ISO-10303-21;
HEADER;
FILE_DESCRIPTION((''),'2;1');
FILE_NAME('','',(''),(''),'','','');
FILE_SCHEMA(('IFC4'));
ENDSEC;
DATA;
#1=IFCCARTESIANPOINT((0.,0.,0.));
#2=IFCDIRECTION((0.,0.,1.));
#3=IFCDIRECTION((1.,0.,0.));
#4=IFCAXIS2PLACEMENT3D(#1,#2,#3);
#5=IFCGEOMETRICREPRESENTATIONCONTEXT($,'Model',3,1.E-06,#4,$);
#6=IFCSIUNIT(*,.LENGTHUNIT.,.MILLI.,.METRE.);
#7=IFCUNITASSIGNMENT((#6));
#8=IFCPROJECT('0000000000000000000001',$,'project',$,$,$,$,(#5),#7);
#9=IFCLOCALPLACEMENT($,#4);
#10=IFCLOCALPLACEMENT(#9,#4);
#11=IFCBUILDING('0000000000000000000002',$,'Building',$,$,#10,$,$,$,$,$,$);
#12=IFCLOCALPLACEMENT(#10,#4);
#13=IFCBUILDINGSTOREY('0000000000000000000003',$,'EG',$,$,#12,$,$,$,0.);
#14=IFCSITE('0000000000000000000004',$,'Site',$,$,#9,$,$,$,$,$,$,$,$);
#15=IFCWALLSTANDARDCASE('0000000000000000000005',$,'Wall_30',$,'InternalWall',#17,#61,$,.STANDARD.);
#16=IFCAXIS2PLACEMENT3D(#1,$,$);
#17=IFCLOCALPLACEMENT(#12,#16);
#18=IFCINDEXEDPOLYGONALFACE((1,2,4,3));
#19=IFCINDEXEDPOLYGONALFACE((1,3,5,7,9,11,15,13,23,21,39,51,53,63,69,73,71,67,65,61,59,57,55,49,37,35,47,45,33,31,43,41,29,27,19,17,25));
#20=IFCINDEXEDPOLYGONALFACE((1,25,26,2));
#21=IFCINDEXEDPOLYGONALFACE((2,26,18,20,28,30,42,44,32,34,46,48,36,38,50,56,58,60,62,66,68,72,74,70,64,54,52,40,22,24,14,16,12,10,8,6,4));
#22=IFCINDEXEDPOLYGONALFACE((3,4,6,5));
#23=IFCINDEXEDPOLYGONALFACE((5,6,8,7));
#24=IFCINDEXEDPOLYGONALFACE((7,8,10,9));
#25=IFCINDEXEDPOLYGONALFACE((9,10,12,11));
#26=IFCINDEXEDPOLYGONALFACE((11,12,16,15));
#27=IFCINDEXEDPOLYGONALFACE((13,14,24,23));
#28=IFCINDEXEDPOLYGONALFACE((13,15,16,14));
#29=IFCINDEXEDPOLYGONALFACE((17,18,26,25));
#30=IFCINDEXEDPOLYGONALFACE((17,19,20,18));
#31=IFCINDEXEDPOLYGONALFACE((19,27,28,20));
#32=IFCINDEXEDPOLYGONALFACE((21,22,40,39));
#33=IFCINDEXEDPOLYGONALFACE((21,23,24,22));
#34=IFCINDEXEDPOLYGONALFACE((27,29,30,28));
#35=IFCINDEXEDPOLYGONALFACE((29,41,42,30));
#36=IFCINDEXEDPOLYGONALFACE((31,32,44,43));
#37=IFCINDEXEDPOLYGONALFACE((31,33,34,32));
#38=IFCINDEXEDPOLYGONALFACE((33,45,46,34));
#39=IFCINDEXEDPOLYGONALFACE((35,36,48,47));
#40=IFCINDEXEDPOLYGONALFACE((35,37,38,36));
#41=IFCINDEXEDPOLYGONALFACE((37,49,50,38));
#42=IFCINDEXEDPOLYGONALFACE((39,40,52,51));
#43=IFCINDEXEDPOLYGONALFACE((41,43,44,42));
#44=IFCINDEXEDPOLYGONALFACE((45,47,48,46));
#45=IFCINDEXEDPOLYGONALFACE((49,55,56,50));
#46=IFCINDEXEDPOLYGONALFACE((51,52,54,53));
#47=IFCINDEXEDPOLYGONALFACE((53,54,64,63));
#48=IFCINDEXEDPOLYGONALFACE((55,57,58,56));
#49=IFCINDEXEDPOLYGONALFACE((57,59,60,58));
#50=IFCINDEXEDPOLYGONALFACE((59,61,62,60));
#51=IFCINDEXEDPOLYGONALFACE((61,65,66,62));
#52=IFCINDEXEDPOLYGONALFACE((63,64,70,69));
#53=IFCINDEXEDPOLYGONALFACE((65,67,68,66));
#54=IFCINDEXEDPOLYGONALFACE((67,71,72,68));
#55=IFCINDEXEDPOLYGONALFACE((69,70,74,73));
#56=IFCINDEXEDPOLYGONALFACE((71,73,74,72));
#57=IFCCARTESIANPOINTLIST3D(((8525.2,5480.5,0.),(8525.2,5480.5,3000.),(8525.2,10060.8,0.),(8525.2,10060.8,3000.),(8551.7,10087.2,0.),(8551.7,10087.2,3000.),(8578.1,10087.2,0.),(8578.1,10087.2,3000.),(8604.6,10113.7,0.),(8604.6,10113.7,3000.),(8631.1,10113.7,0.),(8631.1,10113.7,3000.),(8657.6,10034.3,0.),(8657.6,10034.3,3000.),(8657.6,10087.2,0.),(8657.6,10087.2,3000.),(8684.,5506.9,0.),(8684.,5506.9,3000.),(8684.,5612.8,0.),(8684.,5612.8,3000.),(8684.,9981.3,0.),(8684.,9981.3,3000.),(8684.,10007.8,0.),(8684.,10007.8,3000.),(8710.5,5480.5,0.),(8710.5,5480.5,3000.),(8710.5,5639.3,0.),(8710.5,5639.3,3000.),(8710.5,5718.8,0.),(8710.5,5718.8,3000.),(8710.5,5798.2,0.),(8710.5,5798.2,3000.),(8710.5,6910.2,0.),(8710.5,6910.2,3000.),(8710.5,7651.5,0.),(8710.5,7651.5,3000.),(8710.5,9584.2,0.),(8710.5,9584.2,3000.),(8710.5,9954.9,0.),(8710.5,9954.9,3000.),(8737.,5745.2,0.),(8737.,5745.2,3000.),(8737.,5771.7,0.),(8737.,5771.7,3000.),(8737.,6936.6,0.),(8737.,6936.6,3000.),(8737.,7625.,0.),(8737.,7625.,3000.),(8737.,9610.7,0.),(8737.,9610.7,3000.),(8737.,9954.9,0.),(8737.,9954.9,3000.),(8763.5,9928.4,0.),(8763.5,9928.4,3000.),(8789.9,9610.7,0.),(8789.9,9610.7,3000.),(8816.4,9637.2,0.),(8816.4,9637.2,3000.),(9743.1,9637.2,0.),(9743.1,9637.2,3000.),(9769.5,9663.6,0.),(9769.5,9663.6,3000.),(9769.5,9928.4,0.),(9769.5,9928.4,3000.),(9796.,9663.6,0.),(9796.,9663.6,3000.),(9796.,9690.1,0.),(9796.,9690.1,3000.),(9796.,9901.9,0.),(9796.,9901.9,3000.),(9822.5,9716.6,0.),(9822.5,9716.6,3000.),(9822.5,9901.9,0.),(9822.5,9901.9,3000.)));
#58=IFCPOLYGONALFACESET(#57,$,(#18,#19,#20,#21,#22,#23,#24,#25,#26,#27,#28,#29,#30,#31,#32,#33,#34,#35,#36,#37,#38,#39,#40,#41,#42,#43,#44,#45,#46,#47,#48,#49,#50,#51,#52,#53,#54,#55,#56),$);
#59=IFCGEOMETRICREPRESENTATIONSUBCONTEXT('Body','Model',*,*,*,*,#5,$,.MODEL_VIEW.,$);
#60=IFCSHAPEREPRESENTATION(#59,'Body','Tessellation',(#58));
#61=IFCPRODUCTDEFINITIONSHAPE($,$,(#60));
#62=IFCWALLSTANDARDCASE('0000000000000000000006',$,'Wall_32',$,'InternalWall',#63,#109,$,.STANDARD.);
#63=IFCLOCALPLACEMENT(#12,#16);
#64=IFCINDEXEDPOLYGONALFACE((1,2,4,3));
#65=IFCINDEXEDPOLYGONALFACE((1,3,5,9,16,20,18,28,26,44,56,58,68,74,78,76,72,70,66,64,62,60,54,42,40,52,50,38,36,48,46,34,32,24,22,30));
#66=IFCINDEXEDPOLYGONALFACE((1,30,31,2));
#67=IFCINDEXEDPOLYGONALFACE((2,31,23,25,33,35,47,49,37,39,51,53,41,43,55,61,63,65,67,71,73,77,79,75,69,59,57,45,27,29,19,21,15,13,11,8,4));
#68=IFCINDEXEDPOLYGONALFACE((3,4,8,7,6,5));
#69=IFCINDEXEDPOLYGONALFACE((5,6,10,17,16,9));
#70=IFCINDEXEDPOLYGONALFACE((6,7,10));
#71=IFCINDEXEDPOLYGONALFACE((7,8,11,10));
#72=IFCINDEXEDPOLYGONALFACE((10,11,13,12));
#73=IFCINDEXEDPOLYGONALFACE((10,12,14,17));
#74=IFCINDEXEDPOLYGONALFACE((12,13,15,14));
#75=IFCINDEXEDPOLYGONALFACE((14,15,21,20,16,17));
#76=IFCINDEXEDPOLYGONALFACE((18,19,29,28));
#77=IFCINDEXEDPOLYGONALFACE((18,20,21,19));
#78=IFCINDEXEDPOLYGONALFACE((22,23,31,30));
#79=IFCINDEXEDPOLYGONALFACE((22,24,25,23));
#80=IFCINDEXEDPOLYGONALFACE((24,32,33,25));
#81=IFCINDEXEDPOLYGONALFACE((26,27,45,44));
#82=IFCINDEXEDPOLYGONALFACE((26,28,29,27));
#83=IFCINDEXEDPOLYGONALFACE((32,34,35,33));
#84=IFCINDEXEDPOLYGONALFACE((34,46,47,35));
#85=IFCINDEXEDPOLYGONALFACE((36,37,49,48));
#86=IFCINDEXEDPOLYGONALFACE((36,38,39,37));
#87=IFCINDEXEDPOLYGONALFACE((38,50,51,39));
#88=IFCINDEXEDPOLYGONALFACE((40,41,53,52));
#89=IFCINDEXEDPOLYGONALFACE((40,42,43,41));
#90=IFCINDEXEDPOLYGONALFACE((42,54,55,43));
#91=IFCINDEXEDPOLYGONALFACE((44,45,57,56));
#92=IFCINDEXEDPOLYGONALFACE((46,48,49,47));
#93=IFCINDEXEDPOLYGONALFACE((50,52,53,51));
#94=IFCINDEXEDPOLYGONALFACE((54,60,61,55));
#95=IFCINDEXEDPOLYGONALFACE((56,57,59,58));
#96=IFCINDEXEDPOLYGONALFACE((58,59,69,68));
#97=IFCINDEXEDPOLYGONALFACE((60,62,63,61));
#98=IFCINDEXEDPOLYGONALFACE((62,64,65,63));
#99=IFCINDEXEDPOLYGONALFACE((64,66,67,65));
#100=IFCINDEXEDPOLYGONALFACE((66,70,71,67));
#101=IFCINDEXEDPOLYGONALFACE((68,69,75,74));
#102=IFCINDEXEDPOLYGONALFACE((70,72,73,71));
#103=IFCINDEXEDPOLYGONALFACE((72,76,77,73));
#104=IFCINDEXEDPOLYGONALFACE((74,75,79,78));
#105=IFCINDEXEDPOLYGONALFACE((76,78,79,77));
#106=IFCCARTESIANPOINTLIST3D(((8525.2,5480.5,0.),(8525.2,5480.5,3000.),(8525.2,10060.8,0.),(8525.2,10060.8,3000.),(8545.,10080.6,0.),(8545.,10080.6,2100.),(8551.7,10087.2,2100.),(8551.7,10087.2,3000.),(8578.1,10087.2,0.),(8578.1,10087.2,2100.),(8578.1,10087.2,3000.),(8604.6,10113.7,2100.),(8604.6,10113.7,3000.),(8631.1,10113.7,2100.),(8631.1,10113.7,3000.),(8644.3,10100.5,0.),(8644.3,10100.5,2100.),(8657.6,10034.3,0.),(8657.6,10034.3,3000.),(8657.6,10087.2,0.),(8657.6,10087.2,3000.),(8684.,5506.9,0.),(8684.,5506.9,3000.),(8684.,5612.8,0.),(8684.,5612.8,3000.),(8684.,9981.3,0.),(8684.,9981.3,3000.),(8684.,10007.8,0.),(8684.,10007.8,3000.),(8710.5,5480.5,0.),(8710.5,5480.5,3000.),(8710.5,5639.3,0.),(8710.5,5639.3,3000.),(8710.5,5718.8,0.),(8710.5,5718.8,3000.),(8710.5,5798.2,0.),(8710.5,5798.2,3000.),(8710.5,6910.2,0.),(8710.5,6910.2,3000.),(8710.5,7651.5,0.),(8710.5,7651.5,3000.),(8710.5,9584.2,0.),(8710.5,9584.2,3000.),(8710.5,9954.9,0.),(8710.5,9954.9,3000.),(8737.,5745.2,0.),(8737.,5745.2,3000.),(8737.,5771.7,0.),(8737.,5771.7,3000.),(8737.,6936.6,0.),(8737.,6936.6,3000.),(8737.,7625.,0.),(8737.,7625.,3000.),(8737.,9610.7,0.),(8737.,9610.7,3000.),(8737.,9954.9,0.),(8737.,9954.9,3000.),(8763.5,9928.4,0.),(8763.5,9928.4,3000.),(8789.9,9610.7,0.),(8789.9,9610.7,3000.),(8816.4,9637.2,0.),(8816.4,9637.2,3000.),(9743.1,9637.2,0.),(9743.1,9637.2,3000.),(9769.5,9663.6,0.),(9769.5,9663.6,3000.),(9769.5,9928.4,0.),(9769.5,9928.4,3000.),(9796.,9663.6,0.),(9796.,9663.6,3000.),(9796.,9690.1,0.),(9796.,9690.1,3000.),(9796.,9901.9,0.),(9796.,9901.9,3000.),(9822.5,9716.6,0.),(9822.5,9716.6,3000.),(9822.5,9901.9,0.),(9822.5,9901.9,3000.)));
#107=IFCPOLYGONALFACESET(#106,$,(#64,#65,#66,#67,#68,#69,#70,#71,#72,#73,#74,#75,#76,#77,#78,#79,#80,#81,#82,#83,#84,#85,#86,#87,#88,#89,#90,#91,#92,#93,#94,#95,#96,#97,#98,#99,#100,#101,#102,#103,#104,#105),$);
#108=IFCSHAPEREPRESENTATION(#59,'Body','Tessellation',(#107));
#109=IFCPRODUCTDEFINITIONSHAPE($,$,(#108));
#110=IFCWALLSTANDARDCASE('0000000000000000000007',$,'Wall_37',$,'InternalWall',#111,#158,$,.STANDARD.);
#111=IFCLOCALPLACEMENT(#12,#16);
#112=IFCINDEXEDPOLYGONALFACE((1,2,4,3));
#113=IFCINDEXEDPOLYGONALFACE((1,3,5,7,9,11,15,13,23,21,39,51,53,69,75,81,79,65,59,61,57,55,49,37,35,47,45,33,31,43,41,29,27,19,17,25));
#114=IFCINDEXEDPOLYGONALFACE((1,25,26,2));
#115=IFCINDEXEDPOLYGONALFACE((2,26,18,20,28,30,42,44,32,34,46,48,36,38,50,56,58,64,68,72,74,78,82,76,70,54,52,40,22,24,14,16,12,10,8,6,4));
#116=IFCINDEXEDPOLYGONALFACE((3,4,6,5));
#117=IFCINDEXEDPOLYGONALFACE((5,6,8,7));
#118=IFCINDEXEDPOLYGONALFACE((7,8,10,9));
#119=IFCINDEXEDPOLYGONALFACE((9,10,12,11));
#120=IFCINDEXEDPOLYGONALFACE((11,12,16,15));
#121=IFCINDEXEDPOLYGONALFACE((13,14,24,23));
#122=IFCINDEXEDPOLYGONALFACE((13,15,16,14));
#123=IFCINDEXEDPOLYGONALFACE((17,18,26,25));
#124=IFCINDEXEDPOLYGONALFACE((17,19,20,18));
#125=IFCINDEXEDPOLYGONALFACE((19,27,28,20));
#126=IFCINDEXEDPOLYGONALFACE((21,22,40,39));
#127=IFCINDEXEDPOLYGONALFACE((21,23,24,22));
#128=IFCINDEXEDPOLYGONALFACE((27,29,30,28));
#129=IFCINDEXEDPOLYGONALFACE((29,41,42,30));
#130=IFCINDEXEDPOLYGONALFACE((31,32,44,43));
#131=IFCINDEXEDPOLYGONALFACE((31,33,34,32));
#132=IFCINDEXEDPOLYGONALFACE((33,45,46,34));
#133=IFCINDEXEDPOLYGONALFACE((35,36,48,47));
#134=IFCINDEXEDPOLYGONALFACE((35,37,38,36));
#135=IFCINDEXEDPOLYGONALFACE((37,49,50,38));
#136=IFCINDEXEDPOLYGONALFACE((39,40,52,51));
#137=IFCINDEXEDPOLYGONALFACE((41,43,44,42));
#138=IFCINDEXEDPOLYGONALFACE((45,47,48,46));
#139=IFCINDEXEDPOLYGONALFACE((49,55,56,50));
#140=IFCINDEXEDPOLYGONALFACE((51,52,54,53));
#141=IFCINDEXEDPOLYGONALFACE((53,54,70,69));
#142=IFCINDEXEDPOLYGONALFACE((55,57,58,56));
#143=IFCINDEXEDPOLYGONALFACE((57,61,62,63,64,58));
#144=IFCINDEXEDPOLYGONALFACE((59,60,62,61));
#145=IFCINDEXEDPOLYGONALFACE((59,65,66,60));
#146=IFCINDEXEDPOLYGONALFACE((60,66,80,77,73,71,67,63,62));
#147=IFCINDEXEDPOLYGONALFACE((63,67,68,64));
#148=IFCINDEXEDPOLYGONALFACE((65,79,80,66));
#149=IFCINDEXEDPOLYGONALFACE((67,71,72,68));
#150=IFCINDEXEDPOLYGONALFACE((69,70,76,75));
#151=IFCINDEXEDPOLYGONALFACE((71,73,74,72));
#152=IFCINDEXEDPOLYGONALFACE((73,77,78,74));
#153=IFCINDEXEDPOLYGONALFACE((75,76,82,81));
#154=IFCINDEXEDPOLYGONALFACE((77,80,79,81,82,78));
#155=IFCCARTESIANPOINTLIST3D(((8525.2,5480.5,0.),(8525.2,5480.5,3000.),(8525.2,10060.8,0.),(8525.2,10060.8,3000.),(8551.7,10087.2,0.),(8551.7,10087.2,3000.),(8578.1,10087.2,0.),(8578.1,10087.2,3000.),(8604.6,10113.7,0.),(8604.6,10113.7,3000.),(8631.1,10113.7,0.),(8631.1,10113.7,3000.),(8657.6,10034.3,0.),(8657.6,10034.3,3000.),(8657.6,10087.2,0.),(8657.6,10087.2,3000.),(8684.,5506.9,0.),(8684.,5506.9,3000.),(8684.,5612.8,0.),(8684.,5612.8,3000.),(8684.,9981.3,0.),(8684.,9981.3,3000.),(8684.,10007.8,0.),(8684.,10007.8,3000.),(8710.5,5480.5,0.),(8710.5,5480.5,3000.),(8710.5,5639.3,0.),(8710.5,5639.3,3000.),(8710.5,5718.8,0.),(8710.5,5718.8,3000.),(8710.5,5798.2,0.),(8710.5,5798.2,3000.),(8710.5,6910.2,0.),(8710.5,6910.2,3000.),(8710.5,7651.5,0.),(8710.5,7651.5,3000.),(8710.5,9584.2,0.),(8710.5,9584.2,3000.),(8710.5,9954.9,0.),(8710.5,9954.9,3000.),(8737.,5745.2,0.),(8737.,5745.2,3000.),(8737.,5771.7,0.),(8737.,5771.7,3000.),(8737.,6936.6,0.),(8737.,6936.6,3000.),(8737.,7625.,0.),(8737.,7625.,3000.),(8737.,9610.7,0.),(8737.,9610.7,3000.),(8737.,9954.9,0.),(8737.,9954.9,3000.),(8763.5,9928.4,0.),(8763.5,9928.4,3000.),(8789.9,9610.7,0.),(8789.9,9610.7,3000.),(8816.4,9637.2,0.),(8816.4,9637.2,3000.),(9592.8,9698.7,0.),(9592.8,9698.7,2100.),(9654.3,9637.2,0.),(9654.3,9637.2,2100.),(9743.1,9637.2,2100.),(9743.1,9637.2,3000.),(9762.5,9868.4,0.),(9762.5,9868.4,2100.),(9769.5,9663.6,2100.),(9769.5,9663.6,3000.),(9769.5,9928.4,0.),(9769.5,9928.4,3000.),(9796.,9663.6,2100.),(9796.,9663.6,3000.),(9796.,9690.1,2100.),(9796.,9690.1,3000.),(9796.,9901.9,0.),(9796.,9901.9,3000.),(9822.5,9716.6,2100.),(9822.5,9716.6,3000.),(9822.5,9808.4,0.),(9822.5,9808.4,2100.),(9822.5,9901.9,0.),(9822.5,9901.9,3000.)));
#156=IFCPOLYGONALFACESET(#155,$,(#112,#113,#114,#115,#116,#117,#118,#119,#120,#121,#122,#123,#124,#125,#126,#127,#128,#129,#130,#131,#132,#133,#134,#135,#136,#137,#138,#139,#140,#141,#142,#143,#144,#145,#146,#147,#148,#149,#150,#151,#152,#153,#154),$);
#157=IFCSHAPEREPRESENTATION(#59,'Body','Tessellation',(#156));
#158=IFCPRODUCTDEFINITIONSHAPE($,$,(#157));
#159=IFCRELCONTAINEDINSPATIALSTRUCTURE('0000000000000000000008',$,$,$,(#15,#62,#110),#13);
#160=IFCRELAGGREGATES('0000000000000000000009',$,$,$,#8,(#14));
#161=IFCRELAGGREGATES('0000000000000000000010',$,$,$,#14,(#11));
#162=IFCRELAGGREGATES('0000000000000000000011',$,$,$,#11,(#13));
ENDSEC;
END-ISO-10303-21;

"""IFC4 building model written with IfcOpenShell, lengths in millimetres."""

from ifc_helpers import new_model, si_unit, frame, origin_with_axes, place, context, subcontext, project, spatial, polyline, rectangle, outline, extrude, element, save


model = new_model("IFC4")

# Units and contexts
model_context = context("Model", 3, precision=1e-06, world=origin_with_axes())
body_context = subcontext(model_context, "Body", "Model", "MODEL_VIEW")
ifc_project = project(units=[si_unit("LENGTHUNIT", "METRE", prefix="MILLI")], contexts=[model_context])

# Site, building, storey
site_placement = place(None, origin_with_axes())
site = spatial("IfcSite", under=ifc_project, at=site_placement, Name="Site")
building_placement = place(site_placement, origin_with_axes())
building = spatial("IfcBuilding", under=site, at=building_placement, Name="Building")
storey_placement = place(building_placement, origin_with_axes())
storey = spatial("IfcBuildingStorey", under=building, at=storey_placement, Name="EG", Elevation=0.0)

# Wall
for number, where, z_axis, x_axis, name in (
    (1, (0.0, 0.0, 0.0), (0.0, 0.0, 1.0), (1.0, 0.0, 0.0), "Wall_30"),
):
    element("IfcWallStandardCase", number, at=place(storey_placement, frame(where, z_axis=z_axis, x_axis=x_axis)), inside=storey, Name=name, ObjectType="InternalWall", PredefinedType="STANDARD", context=body_context, shape_type="SweptSolid", body=[
        extrude(outline(polyline([(8525.2, 5480.5, 0.0), (8525.2, 10060.8, 0.0), (8551.7, 10087.2, 0.0), (8578.1, 10087.2, 0.0), (8604.6, 10113.7, 0.0), (8631.1, 10113.7, 0.0), (8657.6, 10087.2, 0.0), (8657.6, 10034.3, 0.0), (8684.0, 10007.8, 0.0), (8684.0, 9981.3, 0.0), (8710.5, 9954.9, 0.0), (8737.0, 9954.9, 0.0), (8763.5, 9928.4, 0.0), (9769.5, 9928.4, 0.0), (9796.0, 9901.9, 0.0), (9822.5, 9901.9, 0.0), (9822.5, 9716.6, 0.0), (9796.0, 9690.1, 0.0), (9796.0, 9663.6, 0.0), (9769.5, 9663.6, 0.0), (9743.1, 9637.2, 0.0), (8816.4, 9637.2, 0.0), (8789.9, 9610.7, 0.0), (8737.0, 9610.7, 0.0), (8710.5, 9584.2, 0.0), (8710.5, 7651.5, 0.0), (8737.0, 7625.0, 0.0), (8737.0, 6936.6, 0.0), (8710.5, 6910.2, 0.0), (8710.5, 5798.2, 0.0), (8737.0, 5771.7, 0.0), (8737.0, 5745.2, 0.0), (8710.5, 5718.8, 0.0), (8710.5, 5639.3, 0.0), (8684.0, 5612.8, 0.0), (8684.0, 5506.9, 0.0), (8710.5, 5480.5, 0.0), (8525.2, 5480.5, 0.0)])), origin_with_axes(), (0.0, 0.0, 1.0), 3000.0),
    ])

# Wall, opening
wall_1_placement = place(storey_placement, origin_with_axes())
wall_1 = element("IfcWallStandardCase", 2, at=wall_1_placement, inside=storey, Name="Wall_32", ObjectType="InternalWall", PredefinedType="STANDARD", context=body_context, shape_type="SweptSolid", body=[
    extrude(outline(polyline([(8525.2, 5480.5, 0.0), (8525.2, 10060.8, 0.0), (8551.7, 10087.2, 0.0), (8578.1, 10087.2, 0.0), (8604.6, 10113.7, 0.0), (8631.1, 10113.7, 0.0), (8657.6, 10087.2, 0.0), (8657.6, 10034.3, 0.0), (8684.0, 10007.8, 0.0), (8684.0, 9981.3, 0.0), (8710.5, 9954.9, 0.0), (8737.0, 9954.9, 0.0), (8763.5, 9928.4, 0.0), (9769.5, 9928.4, 0.0), (9796.0, 9901.9, 0.0), (9822.5, 9901.9, 0.0), (9822.5, 9716.6, 0.0), (9796.0, 9690.1, 0.0), (9796.0, 9663.6, 0.0), (9769.5, 9663.6, 0.0), (9743.1, 9637.2, 0.0), (8816.4, 9637.2, 0.0), (8789.9, 9610.7, 0.0), (8737.0, 9610.7, 0.0), (8710.5, 9584.2, 0.0), (8710.5, 7651.5, 0.0), (8737.0, 7625.0, 0.0), (8737.0, 6936.6, 0.0), (8710.5, 6910.2, 0.0), (8710.5, 5798.2, 0.0), (8737.0, 5771.7, 0.0), (8737.0, 5745.2, 0.0), (8710.5, 5718.8, 0.0), (8710.5, 5639.3, 0.0), (8684.0, 5612.8, 0.0), (8684.0, 5506.9, 0.0), (8710.5, 5480.5, 0.0), (8525.2, 5480.5, 0.0)])), origin_with_axes(), (0.0, 0.0, 1.0), 3000.0),
])
opening_1_placement = place(wall_1_placement, origin_with_axes())
element("IfcOpeningElement", 3, at=opening_1_placement, inside=storey, cuts=wall_1, context=body_context, shape_type="SweptSolid", body=[
    extrude(rectangle(XDim=1344.8, YDim=240.0), frame((8509.4, 10759.2, 0.0), z_axis=(0.0, 0.0, 1.0), x_axis=(-0.196116, 0.980581, 0.0)), (0.0, 0.0, 1.0), 2100.0),
])

# Wall, opening
wall_2_placement = place(storey_placement, origin_with_axes())
wall_2 = element("IfcWallStandardCase", 4, at=wall_2_placement, inside=storey, Name="Wall_37", ObjectType="InternalWall", PredefinedType="STANDARD", context=body_context, shape_type="SweptSolid", body=[
    extrude(outline(polyline([(8525.2, 5480.5, 0.0), (8525.2, 10060.8, 0.0), (8551.7, 10087.2, 0.0), (8578.1, 10087.2, 0.0), (8604.6, 10113.7, 0.0), (8631.1, 10113.7, 0.0), (8657.6, 10087.2, 0.0), (8657.6, 10034.3, 0.0), (8684.0, 10007.8, 0.0), (8684.0, 9981.3, 0.0), (8710.5, 9954.9, 0.0), (8737.0, 9954.9, 0.0), (8763.5, 9928.4, 0.0), (9769.5, 9928.4, 0.0), (9796.0, 9901.9, 0.0), (9822.5, 9901.9, 0.0), (9822.5, 9716.6, 0.0), (9796.0, 9690.1, 0.0), (9796.0, 9663.6, 0.0), (9769.5, 9663.6, 0.0), (9743.1, 9637.2, 0.0), (8816.4, 9637.2, 0.0), (8789.9, 9610.7, 0.0), (8737.0, 9610.7, 0.0), (8710.5, 9584.2, 0.0), (8710.5, 7651.5, 0.0), (8737.0, 7625.0, 0.0), (8737.0, 6936.6, 0.0), (8710.5, 6910.2, 0.0), (8710.5, 5798.2, 0.0), (8737.0, 5771.7, 0.0), (8737.0, 5745.2, 0.0), (8710.5, 5718.8, 0.0), (8710.5, 5639.3, 0.0), (8684.0, 5612.8, 0.0), (8684.0, 5506.9, 0.0), (8710.5, 5480.5, 0.0), (8525.2, 5480.5, 0.0)])), origin_with_axes(), (0.0, 0.0, 1.0), 3000.0),
])
opening_2_placement = place(wall_2_placement, origin_with_axes())
element("IfcOpeningElement", 5, at=opening_2_placement, inside=storey, cuts=wall_2, context=body_context, shape_type="SweptSolid", body=[
    extrude(rectangle(XDim=1347.9, YDim=240.0), frame((10154.2, 9307.0, 0.0), z_axis=(0.0, 0.0, 1.0), x_axis=(0.707107, -0.707107, 0.0)), (0.0, 0.0, 1.0), 2100.0),
])

save(model, "model.ifc")
